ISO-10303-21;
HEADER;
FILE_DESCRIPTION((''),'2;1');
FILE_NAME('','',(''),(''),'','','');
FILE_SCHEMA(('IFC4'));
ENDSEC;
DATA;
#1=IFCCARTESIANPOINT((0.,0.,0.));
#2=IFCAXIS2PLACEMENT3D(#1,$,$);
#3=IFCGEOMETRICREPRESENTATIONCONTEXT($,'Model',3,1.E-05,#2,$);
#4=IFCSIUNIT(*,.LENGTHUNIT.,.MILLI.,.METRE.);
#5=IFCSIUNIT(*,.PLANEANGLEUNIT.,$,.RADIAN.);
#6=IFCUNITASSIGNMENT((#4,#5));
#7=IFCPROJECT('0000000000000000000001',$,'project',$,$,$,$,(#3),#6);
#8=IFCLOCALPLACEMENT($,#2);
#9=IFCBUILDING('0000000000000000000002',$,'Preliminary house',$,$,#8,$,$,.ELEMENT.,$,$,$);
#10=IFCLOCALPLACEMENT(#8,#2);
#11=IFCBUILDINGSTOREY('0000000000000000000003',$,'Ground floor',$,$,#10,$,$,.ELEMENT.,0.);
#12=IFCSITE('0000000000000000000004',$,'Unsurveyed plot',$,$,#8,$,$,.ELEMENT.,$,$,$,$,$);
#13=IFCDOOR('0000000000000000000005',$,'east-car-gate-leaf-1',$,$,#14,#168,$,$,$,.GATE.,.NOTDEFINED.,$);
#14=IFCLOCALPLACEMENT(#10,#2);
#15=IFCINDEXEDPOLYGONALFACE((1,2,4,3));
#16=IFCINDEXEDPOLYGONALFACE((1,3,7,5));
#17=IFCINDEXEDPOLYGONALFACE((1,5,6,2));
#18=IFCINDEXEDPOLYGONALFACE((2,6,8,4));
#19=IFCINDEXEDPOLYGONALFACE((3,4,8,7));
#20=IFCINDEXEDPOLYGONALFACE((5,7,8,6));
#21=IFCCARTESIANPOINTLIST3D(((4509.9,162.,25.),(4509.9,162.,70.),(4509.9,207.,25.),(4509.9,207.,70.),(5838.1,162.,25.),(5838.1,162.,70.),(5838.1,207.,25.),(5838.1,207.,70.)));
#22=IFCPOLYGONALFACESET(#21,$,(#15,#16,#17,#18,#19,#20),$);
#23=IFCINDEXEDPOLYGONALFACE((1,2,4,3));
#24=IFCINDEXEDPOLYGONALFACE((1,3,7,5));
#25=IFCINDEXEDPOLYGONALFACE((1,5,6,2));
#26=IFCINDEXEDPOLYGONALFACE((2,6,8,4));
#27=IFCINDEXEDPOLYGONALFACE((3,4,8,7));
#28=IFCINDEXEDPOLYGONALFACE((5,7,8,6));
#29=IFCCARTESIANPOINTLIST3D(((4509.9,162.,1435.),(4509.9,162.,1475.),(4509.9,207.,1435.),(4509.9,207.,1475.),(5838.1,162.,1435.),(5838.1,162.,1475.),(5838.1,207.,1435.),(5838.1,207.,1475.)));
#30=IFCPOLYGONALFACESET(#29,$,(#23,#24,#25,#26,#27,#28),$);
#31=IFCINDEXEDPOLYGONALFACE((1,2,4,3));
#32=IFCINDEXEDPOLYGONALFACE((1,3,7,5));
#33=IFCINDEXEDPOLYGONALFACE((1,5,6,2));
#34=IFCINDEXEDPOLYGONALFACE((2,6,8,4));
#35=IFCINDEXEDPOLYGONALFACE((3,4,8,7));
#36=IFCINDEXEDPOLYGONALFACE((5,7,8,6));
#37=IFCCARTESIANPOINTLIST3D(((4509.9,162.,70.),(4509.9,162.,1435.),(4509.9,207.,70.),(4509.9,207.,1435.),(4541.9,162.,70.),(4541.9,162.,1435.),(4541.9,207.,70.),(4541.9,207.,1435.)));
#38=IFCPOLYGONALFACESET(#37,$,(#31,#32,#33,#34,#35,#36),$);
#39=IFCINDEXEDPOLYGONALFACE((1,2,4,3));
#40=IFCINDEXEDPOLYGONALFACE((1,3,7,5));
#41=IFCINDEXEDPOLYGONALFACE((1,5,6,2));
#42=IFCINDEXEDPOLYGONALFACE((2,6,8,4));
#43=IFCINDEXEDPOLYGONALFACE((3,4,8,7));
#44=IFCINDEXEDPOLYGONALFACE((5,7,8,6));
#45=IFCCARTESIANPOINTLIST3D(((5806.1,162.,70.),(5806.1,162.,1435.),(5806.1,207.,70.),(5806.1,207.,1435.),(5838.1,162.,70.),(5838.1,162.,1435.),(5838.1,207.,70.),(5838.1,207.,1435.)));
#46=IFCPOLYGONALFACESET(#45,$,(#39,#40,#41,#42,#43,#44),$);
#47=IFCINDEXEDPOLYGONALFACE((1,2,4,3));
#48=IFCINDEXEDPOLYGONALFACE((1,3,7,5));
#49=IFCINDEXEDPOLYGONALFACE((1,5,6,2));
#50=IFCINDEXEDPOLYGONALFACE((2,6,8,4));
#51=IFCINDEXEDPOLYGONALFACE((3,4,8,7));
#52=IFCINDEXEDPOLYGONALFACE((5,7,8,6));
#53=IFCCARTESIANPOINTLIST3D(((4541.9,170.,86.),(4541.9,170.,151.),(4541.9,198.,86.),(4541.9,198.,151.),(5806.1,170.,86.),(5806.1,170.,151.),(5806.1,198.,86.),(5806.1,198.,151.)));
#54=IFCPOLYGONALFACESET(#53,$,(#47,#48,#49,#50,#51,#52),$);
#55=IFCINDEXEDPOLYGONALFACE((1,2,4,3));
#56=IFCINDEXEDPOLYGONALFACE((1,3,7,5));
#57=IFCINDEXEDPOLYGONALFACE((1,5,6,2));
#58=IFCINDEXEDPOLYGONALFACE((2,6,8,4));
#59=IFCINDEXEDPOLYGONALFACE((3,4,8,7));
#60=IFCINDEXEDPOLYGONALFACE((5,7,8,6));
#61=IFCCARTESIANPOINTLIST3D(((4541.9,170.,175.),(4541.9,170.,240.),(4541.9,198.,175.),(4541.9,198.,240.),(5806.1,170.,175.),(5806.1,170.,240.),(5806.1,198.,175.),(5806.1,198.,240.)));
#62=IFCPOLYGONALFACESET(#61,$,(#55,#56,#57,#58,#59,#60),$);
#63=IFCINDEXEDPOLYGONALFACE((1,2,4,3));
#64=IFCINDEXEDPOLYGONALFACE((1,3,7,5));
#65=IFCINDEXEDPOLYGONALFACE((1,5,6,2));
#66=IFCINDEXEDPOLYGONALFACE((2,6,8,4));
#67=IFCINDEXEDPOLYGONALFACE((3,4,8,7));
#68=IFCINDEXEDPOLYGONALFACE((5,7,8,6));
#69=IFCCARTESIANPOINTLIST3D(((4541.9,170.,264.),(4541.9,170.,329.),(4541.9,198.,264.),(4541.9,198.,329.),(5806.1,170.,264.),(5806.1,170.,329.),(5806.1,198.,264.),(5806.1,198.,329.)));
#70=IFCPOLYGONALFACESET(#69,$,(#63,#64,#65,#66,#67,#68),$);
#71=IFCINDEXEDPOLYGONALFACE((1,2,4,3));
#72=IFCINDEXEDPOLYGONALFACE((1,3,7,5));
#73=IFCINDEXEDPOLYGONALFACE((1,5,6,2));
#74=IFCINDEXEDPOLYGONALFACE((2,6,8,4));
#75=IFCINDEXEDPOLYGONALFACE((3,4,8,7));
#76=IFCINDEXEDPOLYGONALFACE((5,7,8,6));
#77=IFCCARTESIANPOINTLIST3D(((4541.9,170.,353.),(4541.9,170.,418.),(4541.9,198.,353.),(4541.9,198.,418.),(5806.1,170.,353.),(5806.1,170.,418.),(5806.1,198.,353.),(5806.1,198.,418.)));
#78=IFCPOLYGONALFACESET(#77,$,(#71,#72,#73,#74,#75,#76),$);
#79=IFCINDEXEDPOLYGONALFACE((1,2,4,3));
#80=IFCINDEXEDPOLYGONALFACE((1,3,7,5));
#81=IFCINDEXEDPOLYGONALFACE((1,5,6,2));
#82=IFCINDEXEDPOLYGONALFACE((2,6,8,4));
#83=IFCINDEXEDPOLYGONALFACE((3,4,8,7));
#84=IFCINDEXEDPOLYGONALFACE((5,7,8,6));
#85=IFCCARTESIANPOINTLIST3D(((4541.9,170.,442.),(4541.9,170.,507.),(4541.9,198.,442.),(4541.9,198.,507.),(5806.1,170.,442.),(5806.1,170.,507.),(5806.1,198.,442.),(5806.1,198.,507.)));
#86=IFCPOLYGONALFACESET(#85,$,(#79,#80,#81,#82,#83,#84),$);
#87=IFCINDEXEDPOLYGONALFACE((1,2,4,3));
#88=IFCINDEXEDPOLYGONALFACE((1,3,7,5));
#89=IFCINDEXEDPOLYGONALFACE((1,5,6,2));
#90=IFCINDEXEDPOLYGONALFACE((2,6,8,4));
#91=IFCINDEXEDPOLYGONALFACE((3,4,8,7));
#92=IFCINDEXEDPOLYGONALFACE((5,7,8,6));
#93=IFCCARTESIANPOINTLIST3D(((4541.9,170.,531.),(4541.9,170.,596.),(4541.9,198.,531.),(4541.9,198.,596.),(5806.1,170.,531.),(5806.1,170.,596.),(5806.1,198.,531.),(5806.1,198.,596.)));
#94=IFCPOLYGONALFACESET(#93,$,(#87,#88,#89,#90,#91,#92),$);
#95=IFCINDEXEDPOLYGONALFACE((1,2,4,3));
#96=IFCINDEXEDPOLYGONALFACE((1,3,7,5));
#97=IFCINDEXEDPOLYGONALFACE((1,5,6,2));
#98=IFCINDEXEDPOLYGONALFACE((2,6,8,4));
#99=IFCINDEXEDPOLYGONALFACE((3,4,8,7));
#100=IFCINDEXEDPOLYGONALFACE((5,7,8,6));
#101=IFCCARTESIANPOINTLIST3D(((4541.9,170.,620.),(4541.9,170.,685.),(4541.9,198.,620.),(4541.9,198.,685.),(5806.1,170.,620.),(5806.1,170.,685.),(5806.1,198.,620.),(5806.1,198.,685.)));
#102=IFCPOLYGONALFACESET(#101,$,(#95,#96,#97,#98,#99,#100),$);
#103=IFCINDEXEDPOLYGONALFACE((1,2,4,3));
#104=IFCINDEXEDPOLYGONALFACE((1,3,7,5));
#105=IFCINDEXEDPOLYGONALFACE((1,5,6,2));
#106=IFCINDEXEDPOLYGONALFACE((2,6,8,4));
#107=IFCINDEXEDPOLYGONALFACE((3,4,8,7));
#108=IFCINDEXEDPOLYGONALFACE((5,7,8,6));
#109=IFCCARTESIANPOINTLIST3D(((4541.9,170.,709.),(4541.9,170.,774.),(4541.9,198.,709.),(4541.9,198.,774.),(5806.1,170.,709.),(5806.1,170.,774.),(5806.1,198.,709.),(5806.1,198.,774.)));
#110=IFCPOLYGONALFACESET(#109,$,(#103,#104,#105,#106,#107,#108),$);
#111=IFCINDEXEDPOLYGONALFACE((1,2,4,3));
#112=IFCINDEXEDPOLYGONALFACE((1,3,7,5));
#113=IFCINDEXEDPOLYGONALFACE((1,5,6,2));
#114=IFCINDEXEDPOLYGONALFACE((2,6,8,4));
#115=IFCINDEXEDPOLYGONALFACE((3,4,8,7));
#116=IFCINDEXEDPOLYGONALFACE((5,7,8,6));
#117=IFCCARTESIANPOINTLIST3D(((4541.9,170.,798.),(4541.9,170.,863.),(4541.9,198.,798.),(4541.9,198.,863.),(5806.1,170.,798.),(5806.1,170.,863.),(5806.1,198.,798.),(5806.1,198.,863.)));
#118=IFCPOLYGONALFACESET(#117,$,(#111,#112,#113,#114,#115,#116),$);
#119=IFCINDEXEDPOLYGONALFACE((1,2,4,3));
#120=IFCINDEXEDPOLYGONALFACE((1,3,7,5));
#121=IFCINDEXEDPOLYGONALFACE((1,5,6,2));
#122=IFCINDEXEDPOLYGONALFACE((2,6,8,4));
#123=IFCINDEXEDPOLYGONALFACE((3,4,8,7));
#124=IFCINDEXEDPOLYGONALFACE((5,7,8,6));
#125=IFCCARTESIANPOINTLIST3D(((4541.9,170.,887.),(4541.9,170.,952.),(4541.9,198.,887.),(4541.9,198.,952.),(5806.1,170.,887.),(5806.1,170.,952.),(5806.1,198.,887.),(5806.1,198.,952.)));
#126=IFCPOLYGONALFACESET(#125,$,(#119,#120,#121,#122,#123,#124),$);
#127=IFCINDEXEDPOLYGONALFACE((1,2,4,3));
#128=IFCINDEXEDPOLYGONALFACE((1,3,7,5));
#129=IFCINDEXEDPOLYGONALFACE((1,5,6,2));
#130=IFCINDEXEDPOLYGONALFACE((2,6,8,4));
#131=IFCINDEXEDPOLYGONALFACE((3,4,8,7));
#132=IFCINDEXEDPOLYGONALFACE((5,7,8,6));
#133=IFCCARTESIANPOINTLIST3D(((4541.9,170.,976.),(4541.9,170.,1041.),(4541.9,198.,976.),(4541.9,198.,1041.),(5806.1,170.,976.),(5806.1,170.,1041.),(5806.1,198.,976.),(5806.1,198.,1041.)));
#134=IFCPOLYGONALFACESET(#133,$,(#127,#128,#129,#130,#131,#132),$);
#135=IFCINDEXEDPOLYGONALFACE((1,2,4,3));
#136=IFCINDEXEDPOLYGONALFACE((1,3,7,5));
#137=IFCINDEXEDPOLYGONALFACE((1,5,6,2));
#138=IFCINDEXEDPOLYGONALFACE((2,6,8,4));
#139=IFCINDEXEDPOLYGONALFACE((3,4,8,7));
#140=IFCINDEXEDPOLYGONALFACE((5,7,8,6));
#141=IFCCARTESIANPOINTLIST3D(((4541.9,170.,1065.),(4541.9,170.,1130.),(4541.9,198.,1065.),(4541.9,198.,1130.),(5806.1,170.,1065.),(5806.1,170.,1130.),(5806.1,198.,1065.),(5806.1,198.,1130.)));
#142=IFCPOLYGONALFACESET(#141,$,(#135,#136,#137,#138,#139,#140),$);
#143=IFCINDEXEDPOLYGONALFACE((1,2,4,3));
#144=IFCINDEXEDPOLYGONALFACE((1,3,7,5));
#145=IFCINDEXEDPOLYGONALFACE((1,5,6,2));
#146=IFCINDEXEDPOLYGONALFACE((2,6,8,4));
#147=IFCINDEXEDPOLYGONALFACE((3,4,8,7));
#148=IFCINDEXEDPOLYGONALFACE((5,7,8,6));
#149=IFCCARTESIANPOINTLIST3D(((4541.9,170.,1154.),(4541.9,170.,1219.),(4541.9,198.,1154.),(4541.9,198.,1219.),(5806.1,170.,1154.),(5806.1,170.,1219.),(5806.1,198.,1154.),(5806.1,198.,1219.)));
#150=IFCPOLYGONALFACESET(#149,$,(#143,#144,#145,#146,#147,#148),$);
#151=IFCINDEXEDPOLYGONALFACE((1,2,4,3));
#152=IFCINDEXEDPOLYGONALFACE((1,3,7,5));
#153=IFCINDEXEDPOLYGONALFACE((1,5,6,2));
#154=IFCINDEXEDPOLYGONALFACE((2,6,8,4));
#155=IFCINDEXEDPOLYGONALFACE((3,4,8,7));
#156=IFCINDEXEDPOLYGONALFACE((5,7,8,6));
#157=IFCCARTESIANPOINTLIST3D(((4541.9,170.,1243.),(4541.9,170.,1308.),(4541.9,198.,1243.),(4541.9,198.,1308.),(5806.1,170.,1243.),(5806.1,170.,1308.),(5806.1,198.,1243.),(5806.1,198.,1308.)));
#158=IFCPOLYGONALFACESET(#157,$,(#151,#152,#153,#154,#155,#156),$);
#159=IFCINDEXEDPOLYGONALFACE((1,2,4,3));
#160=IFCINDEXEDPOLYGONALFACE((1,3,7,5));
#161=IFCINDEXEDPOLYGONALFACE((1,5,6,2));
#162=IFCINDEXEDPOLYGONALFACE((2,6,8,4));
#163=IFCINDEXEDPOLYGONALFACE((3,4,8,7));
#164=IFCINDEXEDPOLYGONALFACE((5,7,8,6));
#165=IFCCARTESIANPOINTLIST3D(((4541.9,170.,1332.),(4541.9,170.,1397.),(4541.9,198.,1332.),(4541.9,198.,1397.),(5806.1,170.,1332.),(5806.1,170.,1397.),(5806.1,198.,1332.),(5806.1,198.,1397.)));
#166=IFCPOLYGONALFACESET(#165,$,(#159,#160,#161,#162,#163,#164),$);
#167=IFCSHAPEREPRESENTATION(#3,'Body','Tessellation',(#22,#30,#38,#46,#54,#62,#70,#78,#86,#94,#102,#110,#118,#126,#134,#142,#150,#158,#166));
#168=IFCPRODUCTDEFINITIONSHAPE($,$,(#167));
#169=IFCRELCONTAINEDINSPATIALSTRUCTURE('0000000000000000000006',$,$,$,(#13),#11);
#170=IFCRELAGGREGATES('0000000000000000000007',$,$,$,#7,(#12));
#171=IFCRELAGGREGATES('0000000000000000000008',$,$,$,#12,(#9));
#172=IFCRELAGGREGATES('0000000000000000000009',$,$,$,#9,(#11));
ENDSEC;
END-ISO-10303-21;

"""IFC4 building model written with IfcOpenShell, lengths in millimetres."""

from ifc_helpers import new_model, si_unit, frame, origin, place, context, project, spatial, polyline, outline, extrude, element, save


model = new_model("IFC4")

# Units and contexts
model_context = context("Model", 3, precision=1e-05, world=origin())
ifc_project = project(units=[si_unit("LENGTHUNIT", "METRE", prefix="MILLI"), si_unit("PLANEANGLEUNIT", "RADIAN")], contexts=[model_context])

# Site, building, storey
placement_1 = place(None, origin())
site = spatial("IfcSite", under=ifc_project, at=placement_1, Name="Unsurveyed plot", CompositionType="ELEMENT")
building = spatial("IfcBuilding", under=site, at=placement_1, Name="Preliminary house", CompositionType="ELEMENT")
placement_2 = place(placement_1, origin())
storey = spatial("IfcBuildingStorey", under=building, at=placement_2, Name="Ground floor", CompositionType="ELEMENT", Elevation=0.0)

# Door
element("IfcDoor", 1, at=placement_2, inside=storey, Name="east-car-gate-leaf-1", OperationType="NOTDEFINED", PredefinedType="GATE", context=model_context, shape_type="SweptSolid", body=[
    extrude(outline(polyline([(5838.1, 162.0), (5838.1, 207.0), (4509.9, 207.0), (4509.9, 162.0), (5838.1, 162.0)])), frame((0.0, 0.0, 25.0)), (0.0, 0.0, 1.0), 45.0),
    extrude(outline(polyline([(5838.1, 162.0), (5838.1, 207.0), (4509.9, 207.0), (4509.9, 162.0), (5838.1, 162.0)])), frame((0.0, 0.0, 1435.0)), (0.0, 0.0, 1.0), 40.0),
    extrude(outline(polyline([(4541.9, 162.0), (4541.9, 207.0), (4509.9, 207.0), (4509.9, 162.0), (4541.9, 162.0)])), frame((0.0, 0.0, 70.0)), (0.0, 0.0, 1.0), 1365.0),
    extrude(outline(polyline([(5838.1, 162.0), (5838.1, 207.0), (5806.1, 207.0), (5806.1, 162.0), (5838.1, 162.0)])), frame((0.0, 0.0, 70.0)), (0.0, 0.0, 1.0), 1365.0),
    extrude(outline(polyline([(5806.1, 170.0), (5806.1, 198.0), (4541.9, 198.0), (4541.9, 170.0), (5806.1, 170.0)])), frame((0.0, 0.0, 86.0)), (0.0, 0.0, 1.0), 65.0),
    extrude(outline(polyline([(5806.1, 170.0), (5806.1, 198.0), (4541.9, 198.0), (4541.9, 170.0), (5806.1, 170.0)])), frame((0.0, 0.0, 175.0)), (0.0, 0.0, 1.0), 65.0),
    extrude(outline(polyline([(5806.1, 170.0), (5806.1, 198.0), (4541.9, 198.0), (4541.9, 170.0), (5806.1, 170.0)])), frame((0.0, 0.0, 264.0)), (0.0, 0.0, 1.0), 65.0),
    extrude(outline(polyline([(5806.1, 170.0), (5806.1, 198.0), (4541.9, 198.0), (4541.9, 170.0), (5806.1, 170.0)])), frame((0.0, 0.0, 353.0)), (0.0, 0.0, 1.0), 65.0),
    extrude(outline(polyline([(5806.1, 170.0), (5806.1, 198.0), (4541.9, 198.0), (4541.9, 170.0), (5806.1, 170.0)])), frame((0.0, 0.0, 442.0)), (0.0, 0.0, 1.0), 65.0),
    extrude(outline(polyline([(5806.1, 170.0), (5806.1, 198.0), (4541.9, 198.0), (4541.9, 170.0), (5806.1, 170.0)])), frame((0.0, 0.0, 531.0)), (0.0, 0.0, 1.0), 65.0),
    extrude(outline(polyline([(5806.1, 170.0), (5806.1, 198.0), (4541.9, 198.0), (4541.9, 170.0), (5806.1, 170.0)])), frame((0.0, 0.0, 620.0)), (0.0, 0.0, 1.0), 65.0),
    extrude(outline(polyline([(5806.1, 170.0), (5806.1, 198.0), (4541.9, 198.0), (4541.9, 170.0), (5806.1, 170.0)])), frame((0.0, 0.0, 709.0)), (0.0, 0.0, 1.0), 65.0),
    extrude(outline(polyline([(5806.1, 170.0), (5806.1, 198.0), (4541.9, 198.0), (4541.9, 170.0), (5806.1, 170.0)])), frame((0.0, 0.0, 798.0)), (0.0, 0.0, 1.0), 65.0),
    extrude(outline(polyline([(5806.1, 170.0), (5806.1, 198.0), (4541.9, 198.0), (4541.9, 170.0), (5806.1, 170.0)])), frame((0.0, 0.0, 887.0)), (0.0, 0.0, 1.0), 65.0),
    extrude(outline(polyline([(5806.1, 170.0), (5806.1, 198.0), (4541.9, 198.0), (4541.9, 170.0), (5806.1, 170.0)])), frame((0.0, 0.0, 976.0)), (0.0, 0.0, 1.0), 65.0),
    extrude(outline(polyline([(5806.1, 170.0), (5806.1, 198.0), (4541.9, 198.0), (4541.9, 170.0), (5806.1, 170.0)])), frame((0.0, 0.0, 1065.0)), (0.0, 0.0, 1.0), 65.0),
    extrude(outline(polyline([(5806.1, 170.0), (5806.1, 198.0), (4541.9, 198.0), (4541.9, 170.0), (5806.1, 170.0)])), frame((0.0, 0.0, 1154.0)), (0.0, 0.0, 1.0), 65.0),
    extrude(outline(polyline([(5806.1, 170.0), (5806.1, 198.0), (4541.9, 198.0), (4541.9, 170.0), (5806.1, 170.0)])), frame((0.0, 0.0, 1243.0)), (0.0, 0.0, 1.0), 65.0),
    extrude(outline(polyline([(5806.1, 170.0), (5806.1, 198.0), (4541.9, 198.0), (4541.9, 170.0), (5806.1, 170.0)])), frame((0.0, 0.0, 1332.0)), (0.0, 0.0, 1.0), 65.0),
])

save(model, "model.ifc")
